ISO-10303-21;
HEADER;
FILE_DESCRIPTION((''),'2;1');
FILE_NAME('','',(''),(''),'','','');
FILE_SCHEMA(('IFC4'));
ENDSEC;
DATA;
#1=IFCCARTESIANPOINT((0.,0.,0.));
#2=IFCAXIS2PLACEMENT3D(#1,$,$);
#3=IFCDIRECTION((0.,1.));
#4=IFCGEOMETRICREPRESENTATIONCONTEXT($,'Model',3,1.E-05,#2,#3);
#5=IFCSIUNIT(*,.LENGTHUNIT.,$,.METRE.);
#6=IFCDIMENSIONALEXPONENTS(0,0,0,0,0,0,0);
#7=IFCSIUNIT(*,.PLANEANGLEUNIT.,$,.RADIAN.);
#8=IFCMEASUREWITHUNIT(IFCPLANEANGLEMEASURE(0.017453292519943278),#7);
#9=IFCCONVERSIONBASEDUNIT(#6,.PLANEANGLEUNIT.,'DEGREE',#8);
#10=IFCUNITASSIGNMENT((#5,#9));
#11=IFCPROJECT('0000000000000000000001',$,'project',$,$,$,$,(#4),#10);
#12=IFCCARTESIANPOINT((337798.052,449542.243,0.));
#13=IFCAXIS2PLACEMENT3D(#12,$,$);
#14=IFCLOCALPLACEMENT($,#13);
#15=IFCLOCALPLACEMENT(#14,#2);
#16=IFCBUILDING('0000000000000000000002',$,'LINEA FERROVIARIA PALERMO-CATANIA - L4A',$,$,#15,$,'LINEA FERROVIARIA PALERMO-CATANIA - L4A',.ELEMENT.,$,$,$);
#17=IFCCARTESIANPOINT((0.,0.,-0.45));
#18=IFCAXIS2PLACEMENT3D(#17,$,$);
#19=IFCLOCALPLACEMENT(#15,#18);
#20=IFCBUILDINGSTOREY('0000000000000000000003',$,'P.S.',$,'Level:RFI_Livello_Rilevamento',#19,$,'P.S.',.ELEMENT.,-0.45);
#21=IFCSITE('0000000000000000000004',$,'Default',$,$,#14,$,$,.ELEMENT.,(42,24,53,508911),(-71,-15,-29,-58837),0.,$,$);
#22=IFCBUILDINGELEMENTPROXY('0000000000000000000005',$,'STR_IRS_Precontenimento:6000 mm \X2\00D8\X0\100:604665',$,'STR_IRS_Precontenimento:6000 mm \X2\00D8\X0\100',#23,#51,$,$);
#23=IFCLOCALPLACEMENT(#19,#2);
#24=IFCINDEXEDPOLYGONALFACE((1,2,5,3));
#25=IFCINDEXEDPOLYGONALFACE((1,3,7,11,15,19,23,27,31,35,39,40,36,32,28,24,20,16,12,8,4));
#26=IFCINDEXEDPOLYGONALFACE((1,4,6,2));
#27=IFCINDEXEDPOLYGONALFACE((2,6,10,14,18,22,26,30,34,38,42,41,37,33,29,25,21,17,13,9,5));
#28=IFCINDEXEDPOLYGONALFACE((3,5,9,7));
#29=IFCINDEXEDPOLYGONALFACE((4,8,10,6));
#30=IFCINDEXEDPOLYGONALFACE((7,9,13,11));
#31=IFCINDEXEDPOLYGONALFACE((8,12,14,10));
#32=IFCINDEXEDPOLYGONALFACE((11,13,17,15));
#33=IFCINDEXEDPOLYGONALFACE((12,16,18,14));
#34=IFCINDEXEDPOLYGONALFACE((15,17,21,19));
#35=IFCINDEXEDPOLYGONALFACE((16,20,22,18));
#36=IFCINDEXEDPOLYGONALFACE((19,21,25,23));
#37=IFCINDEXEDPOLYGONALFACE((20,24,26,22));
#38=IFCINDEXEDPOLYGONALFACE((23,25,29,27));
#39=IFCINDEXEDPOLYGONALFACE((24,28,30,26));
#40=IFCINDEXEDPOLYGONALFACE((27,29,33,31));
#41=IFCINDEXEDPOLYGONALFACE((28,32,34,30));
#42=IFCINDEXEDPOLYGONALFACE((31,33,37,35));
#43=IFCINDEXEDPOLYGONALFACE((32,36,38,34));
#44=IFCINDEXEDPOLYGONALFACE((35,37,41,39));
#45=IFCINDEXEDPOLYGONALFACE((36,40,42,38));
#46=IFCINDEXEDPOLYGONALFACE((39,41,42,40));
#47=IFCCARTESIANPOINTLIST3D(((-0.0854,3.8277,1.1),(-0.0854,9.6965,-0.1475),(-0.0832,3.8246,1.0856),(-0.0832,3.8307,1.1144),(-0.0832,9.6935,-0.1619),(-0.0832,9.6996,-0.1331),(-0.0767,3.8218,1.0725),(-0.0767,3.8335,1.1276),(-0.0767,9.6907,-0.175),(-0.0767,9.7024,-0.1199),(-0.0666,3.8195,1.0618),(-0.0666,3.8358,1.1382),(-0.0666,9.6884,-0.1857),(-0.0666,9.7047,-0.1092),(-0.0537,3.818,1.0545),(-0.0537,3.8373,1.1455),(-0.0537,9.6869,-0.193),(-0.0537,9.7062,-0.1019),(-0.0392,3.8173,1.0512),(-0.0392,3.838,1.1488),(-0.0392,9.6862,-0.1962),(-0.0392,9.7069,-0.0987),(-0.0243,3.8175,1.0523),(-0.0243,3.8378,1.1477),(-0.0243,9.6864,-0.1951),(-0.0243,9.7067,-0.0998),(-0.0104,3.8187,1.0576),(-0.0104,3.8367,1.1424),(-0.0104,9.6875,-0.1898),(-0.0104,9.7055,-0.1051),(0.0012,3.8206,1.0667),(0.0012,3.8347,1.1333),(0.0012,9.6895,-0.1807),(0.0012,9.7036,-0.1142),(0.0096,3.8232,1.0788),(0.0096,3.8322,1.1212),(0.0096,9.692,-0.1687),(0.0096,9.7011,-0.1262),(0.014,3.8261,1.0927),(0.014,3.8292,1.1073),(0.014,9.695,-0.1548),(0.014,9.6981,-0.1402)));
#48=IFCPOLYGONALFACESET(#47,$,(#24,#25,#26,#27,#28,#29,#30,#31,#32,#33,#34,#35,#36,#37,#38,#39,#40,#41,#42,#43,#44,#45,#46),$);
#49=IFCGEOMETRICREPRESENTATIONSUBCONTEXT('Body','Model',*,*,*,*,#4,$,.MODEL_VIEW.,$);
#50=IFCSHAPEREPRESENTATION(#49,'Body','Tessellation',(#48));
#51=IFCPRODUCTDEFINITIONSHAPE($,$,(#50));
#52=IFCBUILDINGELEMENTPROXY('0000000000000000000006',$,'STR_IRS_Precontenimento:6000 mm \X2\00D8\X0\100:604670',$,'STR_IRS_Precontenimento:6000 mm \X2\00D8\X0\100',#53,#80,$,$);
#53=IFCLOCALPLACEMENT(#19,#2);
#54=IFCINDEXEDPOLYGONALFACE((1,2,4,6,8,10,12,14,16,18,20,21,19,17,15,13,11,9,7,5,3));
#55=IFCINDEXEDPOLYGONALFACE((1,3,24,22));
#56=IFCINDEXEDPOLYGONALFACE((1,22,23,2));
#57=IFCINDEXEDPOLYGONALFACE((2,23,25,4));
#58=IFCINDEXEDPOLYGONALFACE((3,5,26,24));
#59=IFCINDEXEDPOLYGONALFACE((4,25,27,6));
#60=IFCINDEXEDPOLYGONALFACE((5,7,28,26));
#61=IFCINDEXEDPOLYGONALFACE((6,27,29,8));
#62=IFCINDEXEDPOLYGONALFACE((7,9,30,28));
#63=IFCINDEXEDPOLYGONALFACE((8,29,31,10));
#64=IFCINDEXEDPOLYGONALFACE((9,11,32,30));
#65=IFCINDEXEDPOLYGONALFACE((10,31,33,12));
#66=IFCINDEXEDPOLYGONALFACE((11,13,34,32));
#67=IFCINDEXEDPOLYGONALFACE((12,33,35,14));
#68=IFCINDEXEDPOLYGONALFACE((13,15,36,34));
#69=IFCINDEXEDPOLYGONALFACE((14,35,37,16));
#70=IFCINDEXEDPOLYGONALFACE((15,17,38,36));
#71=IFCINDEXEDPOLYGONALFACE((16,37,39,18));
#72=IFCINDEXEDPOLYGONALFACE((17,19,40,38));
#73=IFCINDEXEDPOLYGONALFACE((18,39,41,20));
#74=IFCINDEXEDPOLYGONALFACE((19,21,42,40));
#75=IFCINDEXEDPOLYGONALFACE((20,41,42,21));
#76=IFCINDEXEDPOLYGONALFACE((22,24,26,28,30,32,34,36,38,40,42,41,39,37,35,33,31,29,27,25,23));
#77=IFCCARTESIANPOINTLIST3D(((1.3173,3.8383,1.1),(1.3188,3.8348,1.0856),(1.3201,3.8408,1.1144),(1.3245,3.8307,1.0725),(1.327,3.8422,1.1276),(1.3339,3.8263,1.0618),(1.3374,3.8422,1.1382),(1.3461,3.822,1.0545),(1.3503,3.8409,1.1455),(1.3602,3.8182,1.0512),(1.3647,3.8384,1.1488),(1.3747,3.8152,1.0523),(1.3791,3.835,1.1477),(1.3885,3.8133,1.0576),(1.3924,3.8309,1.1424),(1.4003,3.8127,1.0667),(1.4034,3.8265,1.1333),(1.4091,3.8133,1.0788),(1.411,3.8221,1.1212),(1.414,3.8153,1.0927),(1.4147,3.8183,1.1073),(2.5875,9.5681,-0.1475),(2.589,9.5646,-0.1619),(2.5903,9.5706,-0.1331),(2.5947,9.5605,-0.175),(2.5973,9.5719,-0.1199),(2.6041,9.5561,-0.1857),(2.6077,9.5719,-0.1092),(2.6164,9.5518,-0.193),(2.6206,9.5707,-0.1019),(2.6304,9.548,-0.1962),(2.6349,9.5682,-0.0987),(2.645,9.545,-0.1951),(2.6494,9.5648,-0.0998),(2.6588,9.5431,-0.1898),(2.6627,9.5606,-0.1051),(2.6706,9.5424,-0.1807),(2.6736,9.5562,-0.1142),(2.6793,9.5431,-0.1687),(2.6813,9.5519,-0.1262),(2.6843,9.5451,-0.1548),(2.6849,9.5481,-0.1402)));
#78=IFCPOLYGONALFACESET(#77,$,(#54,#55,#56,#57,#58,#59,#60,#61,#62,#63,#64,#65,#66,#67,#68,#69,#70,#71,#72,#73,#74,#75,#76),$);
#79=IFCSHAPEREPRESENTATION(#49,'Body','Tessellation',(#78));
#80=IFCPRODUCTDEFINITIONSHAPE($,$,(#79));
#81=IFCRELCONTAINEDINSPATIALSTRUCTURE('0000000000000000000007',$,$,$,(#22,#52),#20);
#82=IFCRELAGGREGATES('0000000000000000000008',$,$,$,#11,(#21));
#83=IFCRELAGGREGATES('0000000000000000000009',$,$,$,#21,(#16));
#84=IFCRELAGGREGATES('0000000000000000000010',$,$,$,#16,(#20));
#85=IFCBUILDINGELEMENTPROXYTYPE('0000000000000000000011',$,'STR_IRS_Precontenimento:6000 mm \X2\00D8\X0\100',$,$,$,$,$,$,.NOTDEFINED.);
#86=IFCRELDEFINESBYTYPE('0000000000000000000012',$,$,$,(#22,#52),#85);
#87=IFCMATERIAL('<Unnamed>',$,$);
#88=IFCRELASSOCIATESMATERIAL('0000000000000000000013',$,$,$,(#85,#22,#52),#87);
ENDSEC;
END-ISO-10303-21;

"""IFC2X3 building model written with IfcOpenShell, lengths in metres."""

from ifc_helpers import new_model, entity, si_unit, converted_unit, direction, frame, frame_2d, origin, place, context, subcontext, project, spatial, circle, extrude, source, transform, mapped, material, type_object, type_shapes, element, save


model = new_model("IFC2X3")

# Units and contexts
model_context = context("Model", 3, precision=1e-05, world=origin(), true_north=direction((0.0, 1.0)))
body_context = subcontext(model_context, "Body", "Model", "MODEL_VIEW")
ifc_project = project(units=[si_unit("LENGTHUNIT", "METRE"), converted_unit("PLANEANGLEUNIT", "DEGREE", entity("IfcPlaneAngleMeasure", 0.017453292519943278), si_unit("PLANEANGLEUNIT", "RADIAN"), dimensions=[0, 0, 0, 0, 0, 0, 0])], contexts=[model_context])

# Site, building, storey
site_placement = place(None, frame((337798.052, 449542.243, 0.0)))
site = spatial("IfcSite", under=ifc_project, at=site_placement, Name="Default", CompositionType="ELEMENT", RefLatitude=(42, 24, 53, 508911), RefLongitude=(-71, -15, -29, -58837), RefElevation=0.0)
building_placement = place(site_placement, origin())
building = spatial("IfcBuilding", under=site, at=building_placement, Name="LINEA FERROVIARIA PALERMO-CATANIA - L4A", LongName="LINEA FERROVIARIA PALERMO-CATANIA - L4A", CompositionType="ELEMENT")
storey_placement = place(building_placement, frame((0.0, 0.0, -0.45)))
storey = spatial("IfcBuildingStorey", under=building, at=storey_placement, Name="P.S.", ObjectType="Level:RFI_Livello_Rilevamento", LongName="P.S.", CompositionType="ELEMENT", Elevation=-0.45)

# Building element proxies
ifc_material = material(Name="<Unnamed>")
building_element_proxy_type = type_object("IfcBuildingElementProxyType", Name="STR_IRS_Precontenimento:6000 mm Ø100", PredefinedType="NOTDEFINED", material=ifc_material)
shared_shape = source(origin(), body_context, "Body", "SweptSolid", [
    extrude(circle(Radius=0.05, at=frame_2d((0.0, 0.0), x_axis=(1.0, 0.0))), frame((0.0, 0.0, -6.0)), (0.0, 0.0, 1.0), 6.0),
])
type_shapes(building_element_proxy_type, [shared_shape])
for number, where, z_axis, x_axis, name in (
    (1, (-0.0354, 3.8277, 1.1), (0.0, -0.978148, 0.207912), (-1.0, 0.0, 0.0), "STR_IRS_Precontenimento:6000 mm Ø100:604665"),
    (2, (1.3661, 3.8275, 1.1), (-0.21171, -0.954962, 0.207912), (-0.976296, 0.21644, 0.0), "STR_IRS_Precontenimento:6000 mm Ø100:604670"),
):
    element("IfcBuildingElementProxy", number, at=place(storey_placement, frame(where, z_axis=z_axis, x_axis=x_axis)), inside=storey, type_object=building_element_proxy_type, material=ifc_material, Name=name, ObjectType="STR_IRS_Precontenimento:6000 mm Ø100", context=body_context, shape_type="MappedRepresentation", body=[
        mapped(shared_shape, transform((0.0, 0.0, 0.0), scale=1.0)),
    ])

save(model, "model.ifc")
